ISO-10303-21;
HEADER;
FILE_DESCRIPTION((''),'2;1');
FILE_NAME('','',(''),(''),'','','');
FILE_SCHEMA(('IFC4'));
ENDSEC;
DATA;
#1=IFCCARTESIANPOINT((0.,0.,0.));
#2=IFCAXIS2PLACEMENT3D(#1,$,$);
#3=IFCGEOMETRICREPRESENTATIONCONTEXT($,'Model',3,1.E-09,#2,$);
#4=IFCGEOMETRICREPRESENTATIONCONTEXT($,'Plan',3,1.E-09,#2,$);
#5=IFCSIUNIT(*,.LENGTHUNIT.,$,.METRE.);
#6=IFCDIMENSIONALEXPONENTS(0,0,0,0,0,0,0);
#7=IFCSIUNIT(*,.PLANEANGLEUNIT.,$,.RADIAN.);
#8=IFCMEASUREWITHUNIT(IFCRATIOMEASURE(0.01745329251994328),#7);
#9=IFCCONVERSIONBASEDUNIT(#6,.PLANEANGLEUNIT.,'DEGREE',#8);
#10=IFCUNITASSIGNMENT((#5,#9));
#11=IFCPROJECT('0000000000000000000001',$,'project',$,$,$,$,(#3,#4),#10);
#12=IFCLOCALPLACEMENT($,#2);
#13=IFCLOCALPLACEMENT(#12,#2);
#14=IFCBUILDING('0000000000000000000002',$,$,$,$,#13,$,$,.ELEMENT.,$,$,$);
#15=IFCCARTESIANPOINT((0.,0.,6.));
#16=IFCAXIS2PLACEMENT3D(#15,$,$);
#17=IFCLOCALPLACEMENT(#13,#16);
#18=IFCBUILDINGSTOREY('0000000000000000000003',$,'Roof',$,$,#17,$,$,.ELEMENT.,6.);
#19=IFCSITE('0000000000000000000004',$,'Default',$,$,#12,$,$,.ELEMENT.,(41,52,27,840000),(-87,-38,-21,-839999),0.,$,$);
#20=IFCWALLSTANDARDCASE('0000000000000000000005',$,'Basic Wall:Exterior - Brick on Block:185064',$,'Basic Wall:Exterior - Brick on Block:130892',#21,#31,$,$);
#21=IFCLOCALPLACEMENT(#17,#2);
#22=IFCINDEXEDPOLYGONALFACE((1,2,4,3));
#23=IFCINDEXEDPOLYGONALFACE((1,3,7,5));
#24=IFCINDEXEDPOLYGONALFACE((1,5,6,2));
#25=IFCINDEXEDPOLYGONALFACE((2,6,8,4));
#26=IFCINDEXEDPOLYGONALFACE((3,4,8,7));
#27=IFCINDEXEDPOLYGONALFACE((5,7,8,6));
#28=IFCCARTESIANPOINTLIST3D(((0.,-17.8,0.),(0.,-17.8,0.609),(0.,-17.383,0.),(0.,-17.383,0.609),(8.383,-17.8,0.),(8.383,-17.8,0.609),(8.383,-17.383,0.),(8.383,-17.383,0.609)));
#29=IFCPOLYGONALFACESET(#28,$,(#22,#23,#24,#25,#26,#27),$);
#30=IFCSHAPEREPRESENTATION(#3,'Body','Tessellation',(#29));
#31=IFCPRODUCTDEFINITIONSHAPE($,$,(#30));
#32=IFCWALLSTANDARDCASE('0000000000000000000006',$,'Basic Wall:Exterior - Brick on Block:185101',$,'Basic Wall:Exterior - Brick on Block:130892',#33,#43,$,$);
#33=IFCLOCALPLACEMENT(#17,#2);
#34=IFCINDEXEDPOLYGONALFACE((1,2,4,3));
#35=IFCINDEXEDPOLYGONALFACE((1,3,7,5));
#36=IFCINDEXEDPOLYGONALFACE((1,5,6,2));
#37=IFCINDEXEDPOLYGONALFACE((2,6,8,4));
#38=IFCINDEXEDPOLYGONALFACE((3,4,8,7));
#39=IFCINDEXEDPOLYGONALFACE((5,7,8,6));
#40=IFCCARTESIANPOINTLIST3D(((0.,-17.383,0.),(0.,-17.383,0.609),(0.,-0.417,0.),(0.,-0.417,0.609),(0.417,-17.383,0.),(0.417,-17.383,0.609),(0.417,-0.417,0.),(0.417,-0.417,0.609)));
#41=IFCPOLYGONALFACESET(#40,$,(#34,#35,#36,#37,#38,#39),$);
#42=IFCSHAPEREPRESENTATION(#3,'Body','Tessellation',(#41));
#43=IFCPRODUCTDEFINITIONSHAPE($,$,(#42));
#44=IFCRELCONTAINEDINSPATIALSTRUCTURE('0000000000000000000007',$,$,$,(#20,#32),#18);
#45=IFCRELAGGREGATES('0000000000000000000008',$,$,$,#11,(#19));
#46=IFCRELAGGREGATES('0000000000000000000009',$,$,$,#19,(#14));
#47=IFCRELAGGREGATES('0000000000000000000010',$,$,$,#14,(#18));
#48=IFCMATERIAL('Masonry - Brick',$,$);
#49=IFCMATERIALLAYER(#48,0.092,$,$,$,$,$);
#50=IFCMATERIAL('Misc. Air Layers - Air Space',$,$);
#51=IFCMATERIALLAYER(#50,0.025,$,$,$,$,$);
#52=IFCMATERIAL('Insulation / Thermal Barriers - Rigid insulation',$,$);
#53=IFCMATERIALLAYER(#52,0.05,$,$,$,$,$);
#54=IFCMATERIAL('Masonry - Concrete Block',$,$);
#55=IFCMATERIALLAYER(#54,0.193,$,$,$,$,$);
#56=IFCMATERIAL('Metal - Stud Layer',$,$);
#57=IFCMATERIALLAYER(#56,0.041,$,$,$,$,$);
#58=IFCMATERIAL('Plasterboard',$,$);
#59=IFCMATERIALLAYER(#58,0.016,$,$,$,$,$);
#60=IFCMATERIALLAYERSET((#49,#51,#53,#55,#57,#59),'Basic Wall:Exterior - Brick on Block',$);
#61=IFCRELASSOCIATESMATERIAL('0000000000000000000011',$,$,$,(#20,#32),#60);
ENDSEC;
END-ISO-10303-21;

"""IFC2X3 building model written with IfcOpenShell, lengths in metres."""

from ifc_helpers import new_model, entity, si_unit, converted_unit, frame, frame_2d, origin, place, context, project, spatial, rectangle, extrude, material, layer, layer_set, layer_usage, element, save


model = new_model("IFC2X3")

# Units and contexts
model_context = context("Model", 3, precision=1e-09, world=origin())
plan_context = context("Plan", 3, precision=1e-09, world=origin())
ifc_project = project(units=[si_unit("LENGTHUNIT", "METRE"), converted_unit("PLANEANGLEUNIT", "DEGREE", entity("IfcRatioMeasure", 0.01745329251994328), si_unit("PLANEANGLEUNIT", "RADIAN"), dimensions=[0, 0, 0, 0, 0, 0, 0])], contexts=[model_context, plan_context])

# Site, building, storey
site_placement = place(None, origin())
site = spatial("IfcSite", under=ifc_project, at=site_placement, Name="Default", CompositionType="ELEMENT", RefLatitude=(41, 52, 27, 840000), RefLongitude=(-87, -38, -21, -839999), RefElevation=0.0)
building_placement = place(site_placement, origin())
building = spatial("IfcBuilding", under=site, at=building_placement, CompositionType="ELEMENT")
storey_placement = place(building_placement, frame((0.0, 0.0, 6.0)))
storey = spatial("IfcBuildingStorey", under=building, at=storey_placement, Name="Roof", CompositionType="ELEMENT", Elevation=6.0)

# Walls
ifc_material_1 = material(Name="Masonry - Brick")
ifc_layer_1 = layer(ifc_material_1, 0.092)
ifc_material_2 = material(Name="Misc. Air Layers - Air Space")
ifc_layer_2 = layer(ifc_material_2, 0.025)
ifc_material_3 = material(Name="Insulation / Thermal Barriers - Rigid insulation")
ifc_layer_3 = layer(ifc_material_3, 0.05)
ifc_material_4 = material(Name="Masonry - Concrete Block")
ifc_layer_4 = layer(ifc_material_4, 0.193)
ifc_material_5 = material(Name="Metal - Stud Layer")
ifc_layer_5 = layer(ifc_material_5, 0.041)
ifc_material_6 = material(Name="Plasterboard")
ifc_layer_6 = layer(ifc_material_6, 0.016)
ifc_layer_set = layer_set([ifc_layer_1, ifc_layer_2, ifc_layer_3, ifc_layer_4, ifc_layer_5, ifc_layer_6], Name="Basic Wall:Exterior - Brick on Block")
ifc_layer_usage_1 = layer_usage(ifc_layer_set, "AXIS2", "NEGATIVE", 0.2085)
wall_1_placement = place(storey_placement, frame((8.383, -17.5915, 0.0), z_axis=(0.0, 0.0, 1.0), x_axis=(-1.0, 0.0, 0.0)))
element("IfcWallStandardCase", 1, at=wall_1_placement, inside=storey, material=ifc_layer_usage_1, Name="Basic Wall:Exterior - Brick on Block:185064", ObjectType="Basic Wall:Exterior - Brick on Block:130892", context=model_context, shape_type="SweptSolid", body=[
    extrude(rectangle(XDim=8.383, YDim=0.417, at=frame_2d((4.1915, 0.0), x_axis=(-1.0, 0.0))), origin(), (0.0, 0.0, 1.0), 0.609),
])
ifc_layer_usage_2 = layer_usage(ifc_layer_set, "AXIS2", "NEGATIVE", 0.2085)
wall_2_placement = place(storey_placement, frame((0.2085, -17.383, 0.0), z_axis=(0.0, 0.0, 1.0), x_axis=(0.0, 1.0, 0.0)))
element("IfcWallStandardCase", 2, at=wall_2_placement, inside=storey, material=ifc_layer_usage_2, Name="Basic Wall:Exterior - Brick on Block:185101", ObjectType="Basic Wall:Exterior - Brick on Block:130892", context=model_context, shape_type="SweptSolid", body=[
    extrude(rectangle(XDim=16.966, YDim=0.417, at=frame_2d((8.483, 0.0), x_axis=(-1.0, 0.0))), origin(), (0.0, 0.0, 1.0), 0.609),
])

save(model, "model.ifc")
